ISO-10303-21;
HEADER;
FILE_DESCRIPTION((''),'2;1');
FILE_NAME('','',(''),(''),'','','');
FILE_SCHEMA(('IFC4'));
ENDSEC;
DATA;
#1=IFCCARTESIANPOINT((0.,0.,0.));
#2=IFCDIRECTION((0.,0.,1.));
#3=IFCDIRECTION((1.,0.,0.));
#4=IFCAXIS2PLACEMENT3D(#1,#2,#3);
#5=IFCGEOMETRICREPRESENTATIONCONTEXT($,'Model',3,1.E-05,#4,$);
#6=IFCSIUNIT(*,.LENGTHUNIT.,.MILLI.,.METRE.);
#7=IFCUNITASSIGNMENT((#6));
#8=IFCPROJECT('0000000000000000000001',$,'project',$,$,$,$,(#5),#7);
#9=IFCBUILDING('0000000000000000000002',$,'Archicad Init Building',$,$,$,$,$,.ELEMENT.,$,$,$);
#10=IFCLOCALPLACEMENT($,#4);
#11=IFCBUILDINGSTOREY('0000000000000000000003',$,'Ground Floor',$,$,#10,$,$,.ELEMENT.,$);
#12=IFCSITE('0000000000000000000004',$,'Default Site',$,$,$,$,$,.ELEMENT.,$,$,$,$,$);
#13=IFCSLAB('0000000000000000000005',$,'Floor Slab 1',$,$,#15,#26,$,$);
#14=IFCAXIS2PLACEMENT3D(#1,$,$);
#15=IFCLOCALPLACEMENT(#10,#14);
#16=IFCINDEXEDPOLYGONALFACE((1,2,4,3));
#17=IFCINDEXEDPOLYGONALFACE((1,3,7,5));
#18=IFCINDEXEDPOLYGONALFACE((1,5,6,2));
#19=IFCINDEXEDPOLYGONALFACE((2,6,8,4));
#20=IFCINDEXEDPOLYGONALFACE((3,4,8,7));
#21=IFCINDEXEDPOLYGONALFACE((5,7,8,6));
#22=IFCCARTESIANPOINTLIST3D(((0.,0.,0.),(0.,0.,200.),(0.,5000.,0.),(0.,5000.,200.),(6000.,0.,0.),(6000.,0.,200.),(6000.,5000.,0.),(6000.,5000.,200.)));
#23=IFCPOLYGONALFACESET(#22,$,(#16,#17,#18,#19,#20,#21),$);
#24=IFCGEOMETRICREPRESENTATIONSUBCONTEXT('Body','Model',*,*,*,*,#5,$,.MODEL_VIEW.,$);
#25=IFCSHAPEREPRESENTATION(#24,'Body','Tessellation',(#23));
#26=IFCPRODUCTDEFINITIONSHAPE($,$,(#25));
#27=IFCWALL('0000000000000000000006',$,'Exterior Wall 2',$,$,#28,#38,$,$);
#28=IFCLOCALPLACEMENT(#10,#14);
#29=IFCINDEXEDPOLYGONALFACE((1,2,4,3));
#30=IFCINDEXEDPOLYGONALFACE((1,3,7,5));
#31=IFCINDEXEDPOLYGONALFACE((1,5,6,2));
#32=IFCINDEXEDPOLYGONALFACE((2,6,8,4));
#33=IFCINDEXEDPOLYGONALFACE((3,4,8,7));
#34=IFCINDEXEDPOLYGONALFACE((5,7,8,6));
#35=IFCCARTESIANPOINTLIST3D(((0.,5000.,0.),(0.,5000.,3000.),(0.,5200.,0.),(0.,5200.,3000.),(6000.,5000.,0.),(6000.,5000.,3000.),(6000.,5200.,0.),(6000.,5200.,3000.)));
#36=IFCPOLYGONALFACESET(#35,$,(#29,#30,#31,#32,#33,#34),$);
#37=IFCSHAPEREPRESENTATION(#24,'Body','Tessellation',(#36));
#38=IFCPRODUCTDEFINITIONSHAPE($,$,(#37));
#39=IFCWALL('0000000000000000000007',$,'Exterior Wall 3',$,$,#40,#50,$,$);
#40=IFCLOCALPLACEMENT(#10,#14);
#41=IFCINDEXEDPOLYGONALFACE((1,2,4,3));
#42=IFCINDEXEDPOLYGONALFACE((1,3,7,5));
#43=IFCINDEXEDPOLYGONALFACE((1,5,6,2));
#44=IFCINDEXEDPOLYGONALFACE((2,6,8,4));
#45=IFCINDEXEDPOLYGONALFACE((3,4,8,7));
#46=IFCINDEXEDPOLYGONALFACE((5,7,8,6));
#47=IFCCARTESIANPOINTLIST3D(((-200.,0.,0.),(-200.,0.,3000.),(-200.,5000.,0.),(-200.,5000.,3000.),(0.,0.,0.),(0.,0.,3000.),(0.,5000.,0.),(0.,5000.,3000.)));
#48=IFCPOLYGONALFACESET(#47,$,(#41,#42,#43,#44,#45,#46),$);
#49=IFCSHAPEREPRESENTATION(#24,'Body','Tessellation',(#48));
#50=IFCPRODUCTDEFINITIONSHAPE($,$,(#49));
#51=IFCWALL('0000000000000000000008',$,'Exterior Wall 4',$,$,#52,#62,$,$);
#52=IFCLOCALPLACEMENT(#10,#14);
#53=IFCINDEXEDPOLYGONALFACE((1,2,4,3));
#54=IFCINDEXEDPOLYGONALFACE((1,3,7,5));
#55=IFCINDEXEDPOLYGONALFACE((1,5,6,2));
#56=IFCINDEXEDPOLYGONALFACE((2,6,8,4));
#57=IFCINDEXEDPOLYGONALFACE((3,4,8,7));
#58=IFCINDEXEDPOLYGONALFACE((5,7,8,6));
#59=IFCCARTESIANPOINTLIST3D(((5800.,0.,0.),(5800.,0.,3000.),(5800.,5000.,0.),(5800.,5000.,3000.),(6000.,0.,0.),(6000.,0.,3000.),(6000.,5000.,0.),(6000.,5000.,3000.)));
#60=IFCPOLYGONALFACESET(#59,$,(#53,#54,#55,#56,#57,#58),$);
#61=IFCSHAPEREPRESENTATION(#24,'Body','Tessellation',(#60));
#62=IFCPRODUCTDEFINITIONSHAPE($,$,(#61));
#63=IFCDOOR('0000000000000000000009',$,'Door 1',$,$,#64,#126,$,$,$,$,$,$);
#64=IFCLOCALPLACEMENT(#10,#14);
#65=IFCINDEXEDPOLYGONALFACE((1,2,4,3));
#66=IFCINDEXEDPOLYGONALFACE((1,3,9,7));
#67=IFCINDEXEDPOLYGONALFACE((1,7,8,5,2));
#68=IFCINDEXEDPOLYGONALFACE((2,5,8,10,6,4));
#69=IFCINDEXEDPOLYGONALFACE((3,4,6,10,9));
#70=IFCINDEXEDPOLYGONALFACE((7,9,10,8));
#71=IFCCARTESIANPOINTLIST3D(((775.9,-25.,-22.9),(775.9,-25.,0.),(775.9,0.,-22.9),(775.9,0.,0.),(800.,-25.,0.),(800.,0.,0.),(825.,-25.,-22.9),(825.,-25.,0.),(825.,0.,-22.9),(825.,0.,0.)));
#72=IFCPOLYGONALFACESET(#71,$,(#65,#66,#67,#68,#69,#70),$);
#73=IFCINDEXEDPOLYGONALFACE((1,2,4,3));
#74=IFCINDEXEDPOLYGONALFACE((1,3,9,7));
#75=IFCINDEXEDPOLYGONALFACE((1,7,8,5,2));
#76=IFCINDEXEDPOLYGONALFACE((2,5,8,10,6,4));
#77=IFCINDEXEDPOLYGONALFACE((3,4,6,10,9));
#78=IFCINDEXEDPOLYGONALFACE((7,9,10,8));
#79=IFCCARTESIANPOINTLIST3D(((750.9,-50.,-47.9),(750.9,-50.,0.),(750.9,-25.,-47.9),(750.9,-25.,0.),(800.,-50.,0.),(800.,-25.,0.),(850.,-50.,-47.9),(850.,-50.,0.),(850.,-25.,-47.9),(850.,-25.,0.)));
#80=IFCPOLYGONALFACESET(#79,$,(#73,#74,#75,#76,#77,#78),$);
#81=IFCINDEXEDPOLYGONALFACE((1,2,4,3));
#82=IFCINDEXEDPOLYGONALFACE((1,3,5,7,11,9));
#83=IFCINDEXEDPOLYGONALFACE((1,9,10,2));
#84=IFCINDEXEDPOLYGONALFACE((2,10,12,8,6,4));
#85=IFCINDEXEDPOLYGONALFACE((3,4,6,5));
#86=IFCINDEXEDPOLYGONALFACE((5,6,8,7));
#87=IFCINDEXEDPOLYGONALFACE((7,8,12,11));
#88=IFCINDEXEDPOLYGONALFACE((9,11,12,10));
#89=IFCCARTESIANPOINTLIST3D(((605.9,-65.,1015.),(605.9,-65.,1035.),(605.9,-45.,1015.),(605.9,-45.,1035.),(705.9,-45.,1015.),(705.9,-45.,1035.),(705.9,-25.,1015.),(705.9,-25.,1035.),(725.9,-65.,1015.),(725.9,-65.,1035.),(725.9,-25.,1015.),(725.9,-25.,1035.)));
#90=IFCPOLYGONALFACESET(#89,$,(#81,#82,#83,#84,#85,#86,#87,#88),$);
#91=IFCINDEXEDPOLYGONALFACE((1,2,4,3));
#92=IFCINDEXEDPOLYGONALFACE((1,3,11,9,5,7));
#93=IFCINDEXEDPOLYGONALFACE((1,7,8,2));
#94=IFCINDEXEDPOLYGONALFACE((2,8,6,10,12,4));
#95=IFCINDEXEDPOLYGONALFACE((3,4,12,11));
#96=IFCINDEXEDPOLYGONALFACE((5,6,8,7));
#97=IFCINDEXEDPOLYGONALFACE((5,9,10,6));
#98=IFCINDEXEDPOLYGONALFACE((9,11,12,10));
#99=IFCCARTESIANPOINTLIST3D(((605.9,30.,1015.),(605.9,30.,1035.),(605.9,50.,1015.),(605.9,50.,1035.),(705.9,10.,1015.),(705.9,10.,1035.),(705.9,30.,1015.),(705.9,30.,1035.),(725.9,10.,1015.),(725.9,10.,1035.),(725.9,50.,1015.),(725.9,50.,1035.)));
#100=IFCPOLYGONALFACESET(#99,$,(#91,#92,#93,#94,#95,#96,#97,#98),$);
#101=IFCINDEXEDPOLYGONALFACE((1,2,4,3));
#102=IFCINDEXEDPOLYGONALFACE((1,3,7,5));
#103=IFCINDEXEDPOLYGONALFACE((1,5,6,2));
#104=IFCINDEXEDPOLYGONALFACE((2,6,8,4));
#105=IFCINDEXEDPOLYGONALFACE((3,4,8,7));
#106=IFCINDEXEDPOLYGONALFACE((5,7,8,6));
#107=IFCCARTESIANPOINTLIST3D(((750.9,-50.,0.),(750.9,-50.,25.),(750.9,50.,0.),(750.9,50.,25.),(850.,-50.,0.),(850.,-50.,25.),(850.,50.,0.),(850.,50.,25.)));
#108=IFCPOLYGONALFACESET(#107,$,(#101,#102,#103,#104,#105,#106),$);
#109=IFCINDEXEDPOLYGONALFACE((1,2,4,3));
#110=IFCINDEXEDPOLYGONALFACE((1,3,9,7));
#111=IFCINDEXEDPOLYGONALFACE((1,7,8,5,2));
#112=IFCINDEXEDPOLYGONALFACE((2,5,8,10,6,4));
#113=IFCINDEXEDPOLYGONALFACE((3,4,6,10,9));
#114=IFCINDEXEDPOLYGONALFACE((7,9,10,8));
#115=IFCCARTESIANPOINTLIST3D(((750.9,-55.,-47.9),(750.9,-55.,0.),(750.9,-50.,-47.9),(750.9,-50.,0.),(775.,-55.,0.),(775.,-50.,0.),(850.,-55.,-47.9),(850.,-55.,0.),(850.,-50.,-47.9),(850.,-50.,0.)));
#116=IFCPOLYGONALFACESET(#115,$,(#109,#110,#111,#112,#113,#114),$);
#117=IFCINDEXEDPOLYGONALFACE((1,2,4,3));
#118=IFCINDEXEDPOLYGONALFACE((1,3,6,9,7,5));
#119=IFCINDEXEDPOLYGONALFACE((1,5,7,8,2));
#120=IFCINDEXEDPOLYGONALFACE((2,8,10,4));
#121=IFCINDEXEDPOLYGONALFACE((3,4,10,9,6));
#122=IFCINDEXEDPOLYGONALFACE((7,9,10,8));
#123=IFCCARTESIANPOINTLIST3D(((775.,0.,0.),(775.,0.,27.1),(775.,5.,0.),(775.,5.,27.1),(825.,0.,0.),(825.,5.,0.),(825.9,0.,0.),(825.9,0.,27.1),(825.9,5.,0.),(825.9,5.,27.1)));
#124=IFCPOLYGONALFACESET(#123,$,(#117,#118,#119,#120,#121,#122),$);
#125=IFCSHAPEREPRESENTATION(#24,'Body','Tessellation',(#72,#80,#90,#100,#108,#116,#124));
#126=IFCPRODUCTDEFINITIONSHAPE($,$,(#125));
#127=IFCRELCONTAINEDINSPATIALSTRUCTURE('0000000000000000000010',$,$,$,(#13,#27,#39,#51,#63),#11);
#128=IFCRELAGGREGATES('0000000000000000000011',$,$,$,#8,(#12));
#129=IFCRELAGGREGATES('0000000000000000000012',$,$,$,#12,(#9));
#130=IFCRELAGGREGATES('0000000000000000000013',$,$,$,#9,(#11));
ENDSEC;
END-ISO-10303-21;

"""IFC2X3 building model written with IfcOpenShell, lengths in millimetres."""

from ifc_helpers import new_model, si_unit, frame, origin_with_axes, place, context, subcontext, project, spatial, polyline, outline, extrude, element, save


model = new_model("IFC2X3")

# Units and contexts
model_context = context("Model", 3, precision=1e-05, world=origin_with_axes())
body_context = subcontext(model_context, "Body", "Model", "MODEL_VIEW")
ifc_project = project(units=[si_unit("LENGTHUNIT", "METRE", prefix="MILLI")], contexts=[model_context])

# Site, building, storey
site = spatial("IfcSite", under=ifc_project, Name="Default Site", CompositionType="ELEMENT")
building = spatial("IfcBuilding", under=site, Name="Archicad Init Building", CompositionType="ELEMENT")
storey_placement = place(None, origin_with_axes())
storey = spatial("IfcBuildingStorey", under=building, at=storey_placement, Name="Ground Floor", CompositionType="ELEMENT")

# Slab
slab_placement = place(storey_placement, origin_with_axes())
element("IfcSlab", 1, at=slab_placement, inside=storey, Name="Floor Slab 1", context=body_context, shape_type="SweptSolid", body=[
    extrude(outline(polyline([(0.0, 0.0), (6000.0, 0.0), (6000.0, 5000.0), (0.0, 5000.0), (0.0, 0.0)])), origin_with_axes(), (0.0, 0.0, 1.0), 200.0),
])

# Walls
wall_placement = place(storey_placement, frame((0.0, 5000.0, 0.0), z_axis=(0.0, 0.0, 1.0), x_axis=(1.0, 0.0, 0.0)))
element("IfcWall", 2, at=wall_placement, inside=storey, Name="Exterior Wall 2", context=body_context, shape_type="SweptSolid", body=[
    extrude(outline(polyline([(0.0, 0.0), (0.0, 200.0), (6000.0, 200.0), (6000.0, 0.0), (0.0, 0.0)])), origin_with_axes(), (0.0, 0.0, 1.0), 3000.0),
])
for number, where, z_axis, x_axis, name in (
    (3, (0.0, 0.0, 0.0), (0.0, 0.0, 1.0), (0.0, 1.0, 0.0), "Exterior Wall 3"),
    (4, (6000.0, 0.0, 0.0), (0.0, 0.0, 1.0), (0.0, 1.0, 0.0), "Exterior Wall 4"),
):
    element("IfcWall", number, at=place(storey_placement, frame(where, z_axis=z_axis, x_axis=x_axis)), inside=storey, Name=name, context=body_context, shape_type="SweptSolid", body=[
        extrude(outline(polyline([(0.0, 0.0), (0.0, 200.0), (5000.0, 200.0), (5000.0, 0.0), (0.0, 0.0)])), origin_with_axes(), (0.0, 0.0, 1.0), 3000.0),
    ])

# Door
door_placement = place(storey_placement, frame((800.0, -50.0, 0.0), z_axis=(0.0, 0.0, 1.0), x_axis=(1.0, 0.0, 0.0)))
element("IfcDoor", 5, at=door_placement, inside=storey, Name="Door 1", context=body_context, shape_type="SweptSolid", body=[
    extrude(outline(polyline([(0.0, 0.0), (0.0, 2.1), (0.9, 2.1), (0.9, 0.0), (-24.1, 0.0), (-24.1, -22.9), (25.0, -22.9), (25.0, 0.0), (0.0, 0.0)])), frame((0.0, 25.0, 0.0), z_axis=(0.0, -1.0, 0.0), x_axis=(1.0, 0.0, 0.0)), (0.0, 0.0, -1.0), 25.0),
    extrude(outline(polyline([(0.0, 0.0), (0.0, 2.1), (0.9, 2.1), (0.9, 0.0), (-49.1, 0.0), (-49.1, -47.9), (50.0, -47.9), (50.0, 0.0), (0.0, 0.0)])), frame((0.0, 0.0, 0.0), z_axis=(0.0, -1.0, 0.0), x_axis=(1.0, 0.0, 0.0)), (0.0, 0.0, -1.0), 25.0),
    extrude(outline(polyline([(0.0, 0.0), (-49.1, 0.0), (-49.1, 35.0), (0.0, 35.0), (0.0, 0.0)])), frame((25.0, 25.0, 25.0), z_axis=(0.0, 0.0, 1.0), x_axis=(1.0, 0.0, 0.0)), (0.0, 0.0, 1.0), -47.9),
    extrude(outline(polyline([(0.0, 0.0), (0.0, -40.0), (-120.0, -40.0), (-120.0, -20.0), (-20.0, -20.0), (-20.0, 0.0), (0.0, 0.0)])), frame((-74.1, 25.0, 1015.0), z_axis=(0.0, 0.0, 1.0), x_axis=(1.0, 0.0, 0.0)), (0.0, 0.0, 1.0), 20.0),
    extrude(outline(polyline([(0.0, 0.0), (0.0, 40.0), (-120.0, 40.0), (-120.0, 20.0), (-20.0, 20.0), (-20.0, 0.0), (0.0, 0.0)])), frame((-74.1, 60.0, 1015.0), z_axis=(0.0, 0.0, 1.0), x_axis=(1.0, 0.0, 0.0)), (0.0, 0.0, 1.0), 20.0),
    extrude(outline(polyline([(0.0, 0.0), (-99.1, 0.0), (-99.1, 100.0), (0.0, 100.0), (0.0, 0.0)])), frame((50.0, 0.0, 0.0), z_axis=(0.0, 0.0, 1.0), x_axis=(1.0, 0.0, 0.0)), (0.0, 0.0, 1.0), 25.0),
    extrude(outline(polyline([(0.0, 0.0), (0.0, 27.1), (50.9, 27.1), (50.9, 0.0), (-24.1, 0.0), (-24.1, -47.9), (75.0, -47.9), (75.0, 0.0), (0.0, 0.0)])), frame((-25.0, -5.0, 0.0), z_axis=(0.0, -1.0, 0.0), x_axis=(1.0, 0.0, 0.0)), (0.0, 0.0, -1.0), 5.0),
    extrude(outline(polyline([(0.0, 0.0), (0.0, 27.1), (50.9, 27.1), (50.9, 0.0), (0.9, 0.0), (0.9, -22.9), (50.0, -22.9), (50.0, 0.0), (0.0, 0.0)])), frame((-25.0, 50.0, 0.0), z_axis=(0.0, -1.0, 0.0), x_axis=(1.0, 0.0, 0.0)), (0.0, 0.0, -1.0), 5.0),
])

save(model, "model.ifc")
